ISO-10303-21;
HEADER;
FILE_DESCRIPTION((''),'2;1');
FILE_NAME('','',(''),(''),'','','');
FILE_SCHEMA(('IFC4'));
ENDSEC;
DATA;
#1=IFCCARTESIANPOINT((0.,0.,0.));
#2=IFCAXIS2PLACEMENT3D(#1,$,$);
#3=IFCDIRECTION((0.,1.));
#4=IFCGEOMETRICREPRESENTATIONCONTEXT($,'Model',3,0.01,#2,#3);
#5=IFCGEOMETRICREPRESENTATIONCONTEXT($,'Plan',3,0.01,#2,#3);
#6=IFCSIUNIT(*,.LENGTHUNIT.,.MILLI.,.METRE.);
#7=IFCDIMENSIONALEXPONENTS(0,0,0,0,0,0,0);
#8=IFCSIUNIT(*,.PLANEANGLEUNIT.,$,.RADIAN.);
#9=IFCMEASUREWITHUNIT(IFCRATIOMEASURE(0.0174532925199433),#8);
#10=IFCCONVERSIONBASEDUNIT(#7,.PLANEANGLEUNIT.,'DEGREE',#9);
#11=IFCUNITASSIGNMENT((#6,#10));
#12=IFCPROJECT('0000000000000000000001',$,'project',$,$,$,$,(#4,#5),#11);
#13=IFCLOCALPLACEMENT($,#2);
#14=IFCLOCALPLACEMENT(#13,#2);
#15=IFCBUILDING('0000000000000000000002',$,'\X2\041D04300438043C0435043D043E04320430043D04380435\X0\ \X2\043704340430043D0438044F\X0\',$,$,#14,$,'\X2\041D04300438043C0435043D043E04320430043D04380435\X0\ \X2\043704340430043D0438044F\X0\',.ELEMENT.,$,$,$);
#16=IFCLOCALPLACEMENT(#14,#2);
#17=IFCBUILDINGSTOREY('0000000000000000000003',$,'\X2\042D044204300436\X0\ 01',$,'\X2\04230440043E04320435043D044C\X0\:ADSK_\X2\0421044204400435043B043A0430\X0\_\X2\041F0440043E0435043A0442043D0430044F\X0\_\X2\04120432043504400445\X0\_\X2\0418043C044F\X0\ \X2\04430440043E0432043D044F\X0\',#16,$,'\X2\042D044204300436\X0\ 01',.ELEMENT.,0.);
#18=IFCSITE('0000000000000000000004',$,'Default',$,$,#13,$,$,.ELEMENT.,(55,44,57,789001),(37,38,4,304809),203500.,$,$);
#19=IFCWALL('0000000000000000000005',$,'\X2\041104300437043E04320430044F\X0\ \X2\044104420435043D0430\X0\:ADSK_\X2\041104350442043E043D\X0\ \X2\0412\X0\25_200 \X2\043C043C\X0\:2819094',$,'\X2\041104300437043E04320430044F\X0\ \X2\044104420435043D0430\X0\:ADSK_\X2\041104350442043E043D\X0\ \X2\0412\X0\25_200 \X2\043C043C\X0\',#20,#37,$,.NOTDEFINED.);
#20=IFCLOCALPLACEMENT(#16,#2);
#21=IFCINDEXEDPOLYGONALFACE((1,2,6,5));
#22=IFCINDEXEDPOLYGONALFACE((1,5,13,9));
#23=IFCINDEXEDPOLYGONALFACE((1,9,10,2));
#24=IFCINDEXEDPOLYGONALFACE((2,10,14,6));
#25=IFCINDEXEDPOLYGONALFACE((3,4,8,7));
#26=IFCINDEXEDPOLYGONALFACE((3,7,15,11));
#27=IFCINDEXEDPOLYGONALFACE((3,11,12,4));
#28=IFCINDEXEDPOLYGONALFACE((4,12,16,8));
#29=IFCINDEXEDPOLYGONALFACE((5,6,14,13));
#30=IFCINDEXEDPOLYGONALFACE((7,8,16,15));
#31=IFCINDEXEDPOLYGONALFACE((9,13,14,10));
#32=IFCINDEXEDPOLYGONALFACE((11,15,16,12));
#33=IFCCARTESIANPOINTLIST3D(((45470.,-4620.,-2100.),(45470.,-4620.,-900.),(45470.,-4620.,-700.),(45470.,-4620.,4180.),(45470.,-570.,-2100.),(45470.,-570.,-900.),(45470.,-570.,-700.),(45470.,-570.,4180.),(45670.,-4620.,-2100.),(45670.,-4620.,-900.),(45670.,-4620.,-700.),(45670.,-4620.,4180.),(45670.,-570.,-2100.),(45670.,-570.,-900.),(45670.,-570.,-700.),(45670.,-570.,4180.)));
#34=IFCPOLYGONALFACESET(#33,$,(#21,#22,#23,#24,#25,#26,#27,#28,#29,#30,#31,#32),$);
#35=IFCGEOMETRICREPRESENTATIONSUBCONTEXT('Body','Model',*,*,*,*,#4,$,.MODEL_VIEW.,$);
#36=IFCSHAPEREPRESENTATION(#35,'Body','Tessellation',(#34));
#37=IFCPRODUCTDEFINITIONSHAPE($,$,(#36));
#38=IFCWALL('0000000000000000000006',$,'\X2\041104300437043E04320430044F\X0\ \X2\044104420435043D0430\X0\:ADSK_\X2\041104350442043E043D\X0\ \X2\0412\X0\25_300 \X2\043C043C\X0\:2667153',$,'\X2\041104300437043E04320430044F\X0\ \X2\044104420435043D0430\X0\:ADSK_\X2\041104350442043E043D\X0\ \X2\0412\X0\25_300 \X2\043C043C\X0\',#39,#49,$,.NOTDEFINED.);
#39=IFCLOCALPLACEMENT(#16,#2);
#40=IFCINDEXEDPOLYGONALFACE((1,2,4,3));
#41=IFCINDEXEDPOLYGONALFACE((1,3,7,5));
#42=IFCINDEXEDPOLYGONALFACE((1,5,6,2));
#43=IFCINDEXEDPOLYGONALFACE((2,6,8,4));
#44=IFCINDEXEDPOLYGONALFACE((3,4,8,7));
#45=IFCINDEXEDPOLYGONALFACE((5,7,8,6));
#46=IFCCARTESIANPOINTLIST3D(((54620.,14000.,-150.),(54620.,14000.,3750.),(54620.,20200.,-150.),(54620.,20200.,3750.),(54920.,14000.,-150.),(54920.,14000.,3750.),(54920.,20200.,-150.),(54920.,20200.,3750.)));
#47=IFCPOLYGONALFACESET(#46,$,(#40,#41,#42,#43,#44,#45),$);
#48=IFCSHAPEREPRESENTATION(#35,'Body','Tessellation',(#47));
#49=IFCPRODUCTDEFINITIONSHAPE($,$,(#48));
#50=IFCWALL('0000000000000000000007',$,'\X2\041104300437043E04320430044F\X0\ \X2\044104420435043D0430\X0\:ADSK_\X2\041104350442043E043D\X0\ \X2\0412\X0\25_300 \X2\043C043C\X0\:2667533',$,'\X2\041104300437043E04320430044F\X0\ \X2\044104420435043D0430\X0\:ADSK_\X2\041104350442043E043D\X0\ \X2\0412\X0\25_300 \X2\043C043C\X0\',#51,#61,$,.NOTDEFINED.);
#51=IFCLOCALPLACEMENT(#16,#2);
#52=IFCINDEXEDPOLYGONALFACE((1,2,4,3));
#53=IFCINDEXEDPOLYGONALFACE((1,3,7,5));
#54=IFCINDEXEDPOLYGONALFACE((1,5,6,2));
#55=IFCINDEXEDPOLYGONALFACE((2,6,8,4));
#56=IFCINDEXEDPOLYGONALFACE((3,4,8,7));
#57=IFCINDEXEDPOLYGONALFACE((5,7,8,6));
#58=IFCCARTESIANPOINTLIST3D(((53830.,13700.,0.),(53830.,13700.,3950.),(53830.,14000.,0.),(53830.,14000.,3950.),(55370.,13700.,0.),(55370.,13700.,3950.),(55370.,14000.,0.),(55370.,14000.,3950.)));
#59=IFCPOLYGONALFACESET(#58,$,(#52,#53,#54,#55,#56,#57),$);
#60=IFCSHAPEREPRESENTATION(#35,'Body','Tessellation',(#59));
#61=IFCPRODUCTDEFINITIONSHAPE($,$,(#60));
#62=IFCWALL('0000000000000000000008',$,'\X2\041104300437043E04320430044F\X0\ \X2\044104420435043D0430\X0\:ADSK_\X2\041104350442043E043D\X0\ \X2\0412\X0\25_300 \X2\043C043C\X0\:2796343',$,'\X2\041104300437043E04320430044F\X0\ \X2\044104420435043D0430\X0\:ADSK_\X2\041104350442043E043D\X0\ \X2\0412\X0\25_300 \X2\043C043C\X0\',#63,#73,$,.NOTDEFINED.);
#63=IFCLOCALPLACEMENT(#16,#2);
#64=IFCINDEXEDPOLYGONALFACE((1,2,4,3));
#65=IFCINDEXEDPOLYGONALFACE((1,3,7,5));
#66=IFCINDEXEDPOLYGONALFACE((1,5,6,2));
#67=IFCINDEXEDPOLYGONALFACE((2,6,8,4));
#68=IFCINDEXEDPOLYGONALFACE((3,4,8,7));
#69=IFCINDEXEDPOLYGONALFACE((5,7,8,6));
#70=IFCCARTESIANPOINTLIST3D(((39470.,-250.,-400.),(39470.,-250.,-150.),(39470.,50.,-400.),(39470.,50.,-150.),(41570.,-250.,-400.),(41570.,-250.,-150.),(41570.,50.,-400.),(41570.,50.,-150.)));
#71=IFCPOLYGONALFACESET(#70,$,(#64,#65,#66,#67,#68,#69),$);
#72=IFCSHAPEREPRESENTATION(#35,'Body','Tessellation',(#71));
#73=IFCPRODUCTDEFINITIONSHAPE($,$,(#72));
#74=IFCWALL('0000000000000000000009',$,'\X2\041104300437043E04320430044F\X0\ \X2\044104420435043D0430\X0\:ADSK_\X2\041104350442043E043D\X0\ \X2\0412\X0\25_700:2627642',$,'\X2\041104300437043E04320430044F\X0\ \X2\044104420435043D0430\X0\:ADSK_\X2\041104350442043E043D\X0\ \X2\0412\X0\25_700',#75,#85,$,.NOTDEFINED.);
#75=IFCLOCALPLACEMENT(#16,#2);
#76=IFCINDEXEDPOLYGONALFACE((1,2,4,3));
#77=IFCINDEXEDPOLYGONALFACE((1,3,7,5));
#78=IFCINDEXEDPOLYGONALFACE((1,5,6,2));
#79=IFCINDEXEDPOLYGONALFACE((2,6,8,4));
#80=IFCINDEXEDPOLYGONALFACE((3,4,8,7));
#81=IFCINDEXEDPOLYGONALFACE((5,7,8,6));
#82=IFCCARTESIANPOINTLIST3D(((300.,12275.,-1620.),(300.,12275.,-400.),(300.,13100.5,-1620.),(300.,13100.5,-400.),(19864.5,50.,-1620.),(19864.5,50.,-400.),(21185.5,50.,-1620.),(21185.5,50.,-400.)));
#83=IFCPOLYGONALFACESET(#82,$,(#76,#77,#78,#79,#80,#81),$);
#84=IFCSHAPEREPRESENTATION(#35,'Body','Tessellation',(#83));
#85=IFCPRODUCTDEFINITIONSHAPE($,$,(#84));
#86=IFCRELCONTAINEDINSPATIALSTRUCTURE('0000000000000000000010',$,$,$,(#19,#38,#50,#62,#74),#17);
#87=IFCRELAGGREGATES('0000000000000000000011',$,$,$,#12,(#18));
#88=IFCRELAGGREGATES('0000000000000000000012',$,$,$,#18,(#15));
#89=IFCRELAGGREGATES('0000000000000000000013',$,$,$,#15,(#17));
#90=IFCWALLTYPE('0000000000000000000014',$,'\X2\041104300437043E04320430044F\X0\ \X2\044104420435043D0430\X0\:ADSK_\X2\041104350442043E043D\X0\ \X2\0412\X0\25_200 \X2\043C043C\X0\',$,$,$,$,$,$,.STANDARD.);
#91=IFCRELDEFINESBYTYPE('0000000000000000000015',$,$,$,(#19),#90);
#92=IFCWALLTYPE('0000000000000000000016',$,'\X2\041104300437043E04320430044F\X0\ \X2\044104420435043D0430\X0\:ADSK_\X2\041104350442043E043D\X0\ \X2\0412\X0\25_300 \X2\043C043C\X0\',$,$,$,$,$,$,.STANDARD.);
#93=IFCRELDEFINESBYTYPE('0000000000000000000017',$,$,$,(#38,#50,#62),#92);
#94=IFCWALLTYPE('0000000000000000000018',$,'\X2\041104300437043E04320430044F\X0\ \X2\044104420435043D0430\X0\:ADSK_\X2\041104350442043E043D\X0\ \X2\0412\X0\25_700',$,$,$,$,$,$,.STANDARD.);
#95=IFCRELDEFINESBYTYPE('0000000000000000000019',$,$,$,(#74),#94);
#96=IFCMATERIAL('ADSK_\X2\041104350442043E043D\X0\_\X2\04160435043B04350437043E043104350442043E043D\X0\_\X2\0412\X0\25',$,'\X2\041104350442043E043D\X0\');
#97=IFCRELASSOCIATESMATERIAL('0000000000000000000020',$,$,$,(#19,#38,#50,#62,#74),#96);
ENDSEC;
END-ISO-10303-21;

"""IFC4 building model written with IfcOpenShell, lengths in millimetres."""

from ifc_helpers import new_model, entity, si_unit, converted_unit, direction, frame, origin, place, context, subcontext, project, spatial, indexed_curve, outline, extrude, material, type_object, element, save


model = new_model("IFC4")

# Units and contexts
model_context = context("Model", 3, precision=0.01, world=origin(), true_north=direction((0.0, 1.0)))
plan_context = context("Plan", 3, precision=0.01, world=origin(), true_north=direction((0.0, 1.0)))
body_context = subcontext(model_context, "Body", "Model", "MODEL_VIEW")
ifc_project = project(units=[si_unit("LENGTHUNIT", "METRE", prefix="MILLI"), converted_unit("PLANEANGLEUNIT", "DEGREE", entity("IfcRatioMeasure", 0.0174532925199433), si_unit("PLANEANGLEUNIT", "RADIAN"), dimensions=[0, 0, 0, 0, 0, 0, 0])], contexts=[model_context, plan_context])

# Site, building, storey
site_placement = place(None, origin())
site = spatial("IfcSite", under=ifc_project, at=site_placement, Name="Default", CompositionType="ELEMENT", RefLatitude=(55, 44, 57, 789001), RefLongitude=(37, 38, 4, 304809), RefElevation=203500.0)
building_placement = place(site_placement, origin())
building = spatial("IfcBuilding", under=site, at=building_placement, Name="Наименование здания", LongName="Наименование здания", CompositionType="ELEMENT")
storey_placement = place(building_placement, origin())
storey = spatial("IfcBuildingStorey", under=building, at=storey_placement, Name="Этаж 01", ObjectType="Уровень:ADSK_Стрелка_Проектная_Вверх_Имя уровня", LongName="Этаж 01", CompositionType="ELEMENT", Elevation=0.0)

# Shared definitions
ifc_material = material(Name="ADSK_Бетон_Железобетон_В25", Category="Бетон")
wall_type_1 = type_object("IfcWallType", Name="Базовая стена:ADSK_Бетон В25_200 мм", PredefinedType="STANDARD")

# Wall, opening
placement = place(storey_placement, frame((45570.0, -4620.0, -2100.0), z_axis=(0.0, 0.0, 1.0), x_axis=(0.0, 1.0, 0.0)))
wall_1 = element("IfcWall", 1, at=placement, inside=storey, type_object=wall_type_1, material=ifc_material, Name="Базовая стена:ADSK_Бетон В25_200 мм:2819094", ObjectType="Базовая стена:ADSK_Бетон В25_200 мм", PredefinedType="NOTDEFINED", context=body_context, shape_type="SweptSolid", body=[
    extrude(outline(indexed_curve([(4050.0, 100.0), (0.0, 100.0), (0.0, -100.0), (4050.0, -100.0), (4050.0, 100.0)], self_intersect=False)), origin(), (0.0, 0.0, 1.0), 6280.0),
])
element("IfcOpeningElement", 2, at=placement, cuts=wall_1, PredefinedType="OPENING", context=body_context, shape_type="SweptSolid", body=[
    extrude(outline(indexed_curve([(-2025.0, -100.0), (2025.0, -100.0), (2025.0, 100.0), (-2025.0, 100.0), (-2025.0, -100.0)], self_intersect=False)), frame((2025.0, 0.0, 1200.0)), (0.0, 0.0, 1.0), 200.0),
])

# Walls
wall_type_2 = type_object("IfcWallType", Name="Базовая стена:ADSK_Бетон В25_300 мм", PredefinedType="STANDARD")
wall_2_placement = place(storey_placement, frame((54770.0, 20200.0, -150.0), z_axis=(0.0, 0.0, 1.0), x_axis=(0.0, -1.0, 0.0)))
element("IfcWall", 3, at=wall_2_placement, inside=storey, type_object=wall_type_2, material=ifc_material, Name="Базовая стена:ADSK_Бетон В25_300 мм:2667153", ObjectType="Базовая стена:ADSK_Бетон В25_300 мм", PredefinedType="NOTDEFINED", context=body_context, shape_type="SweptSolid", body=[
    extrude(outline(indexed_curve([(6200.0, 150.0), (0.0, 150.0), (0.0, -150.0), (6200.0, -150.0), (6200.0, 150.0)], self_intersect=False)), origin(), (0.0, 0.0, 1.0), 3900.0),
])
wall_3_placement = place(storey_placement, frame((55370.0, 13850.0, 0.0), z_axis=(0.0, 0.0, 1.0), x_axis=(-1.0, 0.0, 0.0)))
element("IfcWall", 4, at=wall_3_placement, inside=storey, type_object=wall_type_2, material=ifc_material, Name="Базовая стена:ADSK_Бетон В25_300 мм:2667533", ObjectType="Базовая стена:ADSK_Бетон В25_300 мм", PredefinedType="NOTDEFINED", context=body_context, shape_type="SweptSolid", body=[
    extrude(outline(indexed_curve([(1540.0, 150.0), (0.0, 150.0), (0.0, -150.0), (1540.0, -150.0), (1540.0, 150.0)], self_intersect=False)), origin(), (0.0, 0.0, 1.0), 3950.0),
])
wall_4_placement = place(storey_placement, frame((39470.0, -100.0, -400.0)))
element("IfcWall", 5, at=wall_4_placement, inside=storey, type_object=wall_type_2, material=ifc_material, Name="Базовая стена:ADSK_Бетон В25_300 мм:2796343", ObjectType="Базовая стена:ADSK_Бетон В25_300 мм", PredefinedType="NOTDEFINED", context=body_context, shape_type="SweptSolid", body=[
    extrude(outline(indexed_curve([(2100.0, 150.0), (0.0, 150.0), (0.0, -150.0), (2100.0, -150.0), (2100.0, 150.0)], self_intersect=False)), origin(), (0.0, 0.0, 1.0), 250.0),
])
wall_type_3 = type_object("IfcWallType", Name="Базовая стена:ADSK_Бетон В25_700", PredefinedType="STANDARD")
wall_5_placement = place(storey_placement, frame((21000.0, -246.8, -1620.0), z_axis=(0.0, 0.0, 1.0), x_axis=(-0.848053, 0.529912, 0.0)))
element("IfcWall", 6, at=wall_5_placement, inside=storey, type_object=wall_type_3, material=ifc_material, Name="Базовая стена:ADSK_Бетон В25_700:2627642", ObjectType="Базовая стена:ADSK_Бетон В25_700", PredefinedType="NOTDEFINED", context=body_context, shape_type="SweptSolid", body=[
    extrude(outline(indexed_curve([(24627.6, -350.0), (24190.2, 350.0), (1120.3, 350.0), (0.0, -350.0), (24627.6, -350.0)], self_intersect=False)), origin(), (0.0, 0.0, 1.0), 1220.0),
])

save(model, "model.ifc")
